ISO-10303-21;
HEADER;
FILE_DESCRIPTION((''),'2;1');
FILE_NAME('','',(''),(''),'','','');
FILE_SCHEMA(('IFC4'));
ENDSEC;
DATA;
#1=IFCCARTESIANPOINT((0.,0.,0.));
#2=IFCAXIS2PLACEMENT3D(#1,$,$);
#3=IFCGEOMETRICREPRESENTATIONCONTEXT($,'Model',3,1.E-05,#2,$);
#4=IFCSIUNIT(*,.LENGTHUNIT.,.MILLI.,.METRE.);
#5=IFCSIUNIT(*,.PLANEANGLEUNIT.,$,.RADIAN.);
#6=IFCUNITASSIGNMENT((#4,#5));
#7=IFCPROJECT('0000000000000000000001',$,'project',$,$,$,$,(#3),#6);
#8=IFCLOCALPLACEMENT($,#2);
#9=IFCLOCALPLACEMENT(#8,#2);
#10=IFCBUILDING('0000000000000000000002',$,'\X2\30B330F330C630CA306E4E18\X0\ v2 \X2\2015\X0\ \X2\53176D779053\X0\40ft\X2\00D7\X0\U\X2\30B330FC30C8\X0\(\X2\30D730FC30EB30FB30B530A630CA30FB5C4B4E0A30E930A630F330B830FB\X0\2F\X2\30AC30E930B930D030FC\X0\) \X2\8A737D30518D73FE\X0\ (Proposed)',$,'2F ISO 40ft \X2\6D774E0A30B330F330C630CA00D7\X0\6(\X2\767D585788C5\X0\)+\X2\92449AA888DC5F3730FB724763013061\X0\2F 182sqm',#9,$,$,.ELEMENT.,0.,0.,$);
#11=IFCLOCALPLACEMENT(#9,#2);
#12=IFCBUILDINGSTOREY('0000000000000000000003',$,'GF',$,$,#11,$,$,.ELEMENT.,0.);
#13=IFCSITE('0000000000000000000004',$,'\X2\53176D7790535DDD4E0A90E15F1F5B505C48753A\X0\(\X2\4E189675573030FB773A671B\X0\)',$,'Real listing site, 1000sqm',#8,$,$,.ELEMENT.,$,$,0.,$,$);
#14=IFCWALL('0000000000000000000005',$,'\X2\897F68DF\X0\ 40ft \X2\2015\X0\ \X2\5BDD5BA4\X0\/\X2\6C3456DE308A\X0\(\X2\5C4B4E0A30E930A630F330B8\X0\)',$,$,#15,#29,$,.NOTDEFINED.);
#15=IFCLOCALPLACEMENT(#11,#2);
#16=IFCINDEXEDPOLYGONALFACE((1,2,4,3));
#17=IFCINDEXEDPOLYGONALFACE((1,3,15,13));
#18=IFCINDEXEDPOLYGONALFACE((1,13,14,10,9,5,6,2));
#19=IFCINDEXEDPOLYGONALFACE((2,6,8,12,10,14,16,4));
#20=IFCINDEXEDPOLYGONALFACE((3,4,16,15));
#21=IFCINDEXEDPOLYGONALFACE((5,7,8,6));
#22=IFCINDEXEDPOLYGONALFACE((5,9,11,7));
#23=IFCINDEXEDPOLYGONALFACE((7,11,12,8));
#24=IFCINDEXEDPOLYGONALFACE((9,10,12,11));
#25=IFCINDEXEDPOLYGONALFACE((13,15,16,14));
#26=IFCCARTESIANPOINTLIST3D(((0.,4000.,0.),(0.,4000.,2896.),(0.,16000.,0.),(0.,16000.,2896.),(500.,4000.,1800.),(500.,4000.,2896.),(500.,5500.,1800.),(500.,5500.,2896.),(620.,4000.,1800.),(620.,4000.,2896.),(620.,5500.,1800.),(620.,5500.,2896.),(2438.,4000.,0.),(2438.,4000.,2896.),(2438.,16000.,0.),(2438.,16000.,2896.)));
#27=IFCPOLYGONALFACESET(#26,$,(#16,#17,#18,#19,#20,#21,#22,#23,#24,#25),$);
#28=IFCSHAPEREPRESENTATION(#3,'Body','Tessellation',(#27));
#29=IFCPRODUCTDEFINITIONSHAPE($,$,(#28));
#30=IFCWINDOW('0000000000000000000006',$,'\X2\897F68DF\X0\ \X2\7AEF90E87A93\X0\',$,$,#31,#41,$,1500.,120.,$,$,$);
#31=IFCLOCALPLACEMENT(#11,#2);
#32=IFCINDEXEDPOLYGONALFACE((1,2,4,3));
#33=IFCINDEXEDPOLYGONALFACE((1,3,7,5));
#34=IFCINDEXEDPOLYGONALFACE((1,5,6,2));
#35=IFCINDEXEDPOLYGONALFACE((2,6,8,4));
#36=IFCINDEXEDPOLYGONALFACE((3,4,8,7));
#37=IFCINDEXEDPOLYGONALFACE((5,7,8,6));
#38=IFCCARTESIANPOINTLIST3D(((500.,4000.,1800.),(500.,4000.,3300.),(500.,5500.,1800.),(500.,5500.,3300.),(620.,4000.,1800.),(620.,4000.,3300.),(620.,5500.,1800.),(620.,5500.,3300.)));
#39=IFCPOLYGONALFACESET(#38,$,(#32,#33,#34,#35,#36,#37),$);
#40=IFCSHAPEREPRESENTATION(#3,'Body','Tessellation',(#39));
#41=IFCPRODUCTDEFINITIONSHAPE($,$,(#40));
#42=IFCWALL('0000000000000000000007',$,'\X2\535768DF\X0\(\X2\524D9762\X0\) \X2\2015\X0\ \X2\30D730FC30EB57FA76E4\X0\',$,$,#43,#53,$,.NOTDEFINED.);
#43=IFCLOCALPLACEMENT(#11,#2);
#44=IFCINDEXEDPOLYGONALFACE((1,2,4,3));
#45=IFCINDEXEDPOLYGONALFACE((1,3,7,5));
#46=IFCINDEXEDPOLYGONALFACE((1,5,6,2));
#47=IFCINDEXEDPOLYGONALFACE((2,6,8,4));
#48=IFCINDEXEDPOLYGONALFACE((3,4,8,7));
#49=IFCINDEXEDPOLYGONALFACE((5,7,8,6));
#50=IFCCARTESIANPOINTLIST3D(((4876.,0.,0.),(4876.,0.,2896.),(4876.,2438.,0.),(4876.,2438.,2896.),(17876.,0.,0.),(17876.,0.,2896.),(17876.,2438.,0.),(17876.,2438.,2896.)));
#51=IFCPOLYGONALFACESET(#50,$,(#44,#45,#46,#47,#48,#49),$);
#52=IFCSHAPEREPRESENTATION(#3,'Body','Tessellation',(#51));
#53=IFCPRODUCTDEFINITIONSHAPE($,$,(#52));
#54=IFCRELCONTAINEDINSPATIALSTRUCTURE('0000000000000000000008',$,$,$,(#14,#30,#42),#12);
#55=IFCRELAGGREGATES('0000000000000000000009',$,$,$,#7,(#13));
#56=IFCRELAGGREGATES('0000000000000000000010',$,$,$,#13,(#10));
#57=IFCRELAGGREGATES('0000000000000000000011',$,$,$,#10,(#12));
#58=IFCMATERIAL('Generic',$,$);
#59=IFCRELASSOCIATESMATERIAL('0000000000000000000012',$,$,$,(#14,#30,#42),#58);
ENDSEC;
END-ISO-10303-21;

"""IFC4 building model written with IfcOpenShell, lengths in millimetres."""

from ifc_helpers import new_model, si_unit, frame, frame_2d, origin, place, context, project, spatial, rectangle, extrude, material, element, fill, save


model = new_model("IFC4")

# Units and contexts
model_context = context("Model", 3, precision=1e-05, world=origin())
ifc_project = project(units=[si_unit("LENGTHUNIT", "METRE", prefix="MILLI"), si_unit("PLANEANGLEUNIT", "RADIAN")], contexts=[model_context])

# Site, building, storey
site_placement = place(None, origin())
site = spatial("IfcSite", under=ifc_project, at=site_placement, Name="北海道川上郡弟子屈町(丘陵地・眺望)", ObjectType="Real listing site, 1000sqm", CompositionType="ELEMENT", RefElevation=0.0)
building_placement = place(site_placement, origin())
building = spatial("IfcBuilding", under=site, at=building_placement, Name="コンテナの丘 v2 ― 北海道40ft×Uコート(プール・サウナ・屋上ラウンジ・2Fガラスバー) 詳細再現 (Proposed)", ObjectType="2F ISO 40ft 海上コンテナ×6(白塗装)+鉄骨補強・片持ち2F 182sqm", CompositionType="ELEMENT", ElevationOfRefHeight=0.0, ElevationOfTerrain=0.0)
storey_placement = place(building_placement, origin())
storey = spatial("IfcBuildingStorey", under=building, at=storey_placement, Name="GF", CompositionType="ELEMENT", Elevation=0.0)

# Shared definitions
ifc_material = material(Name="Generic")

# Wall, opening, window
wall_1_placement = place(storey_placement, frame((0.0, 2000.0, 0.0)))
wall_1 = element("IfcWall", 1, at=wall_1_placement, inside=storey, material=ifc_material, Name="西棟 40ft ― 寝室/水回り(屋上ラウンジ)", PredefinedType="NOTDEFINED", context=model_context, shape_type="SweptSolid", body=[
    extrude(rectangle(XDim=2438.0, YDim=12000.0, at=frame_2d((1219.0, 6000.0))), frame((0.0, 2000.0, 0.0)), (0.0, 0.0, 1.0), 2896.0),
])
opening_placement = place(storey_placement, frame((250.0, 2000.0, 900.0)))
opening = element("IfcOpeningElement", 2, at=opening_placement, cuts=wall_1, PredefinedType="NOTDEFINED", context=model_context, shape_type="SweptSolid", body=[
    extrude(rectangle(XDim=120.0, YDim=1500.0, at=frame_2d((60.0, 750.0))), frame((250.0, 2000.0, 900.0)), (0.0, 0.0, 1.0), 1500.0),
])
window_placement = place(storey_placement, frame((250.0, 2000.0, 900.0)))
window = element("IfcWindow", 3, at=window_placement, inside=storey, material=ifc_material, Name="西棟 端部窓", OverallHeight=1500.0, OverallWidth=120.0, context=model_context, shape_type="SweptSolid", body=[
    extrude(rectangle(XDim=120.0, YDim=1500.0, at=frame_2d((60.0, 750.0))), frame((250.0, 2000.0, 900.0)), (0.0, 0.0, 1.0), 1500.0),
])
fill(opening, window)

# Wall
wall_2_placement = place(storey_placement, frame((2438.0, 0.0, 0.0)))
element("IfcWall", 4, at=wall_2_placement, inside=storey, material=ifc_material, Name="南棟(前面) ― プール基盤", PredefinedType="NOTDEFINED", context=model_context, shape_type="SweptSolid", body=[
    extrude(rectangle(XDim=13000.0, YDim=2438.0, at=frame_2d((6500.0, 1219.0))), frame((2438.0, 0.0, 0.0)), (0.0, 0.0, 1.0), 2896.0),
])

save(model, "model.ifc")
